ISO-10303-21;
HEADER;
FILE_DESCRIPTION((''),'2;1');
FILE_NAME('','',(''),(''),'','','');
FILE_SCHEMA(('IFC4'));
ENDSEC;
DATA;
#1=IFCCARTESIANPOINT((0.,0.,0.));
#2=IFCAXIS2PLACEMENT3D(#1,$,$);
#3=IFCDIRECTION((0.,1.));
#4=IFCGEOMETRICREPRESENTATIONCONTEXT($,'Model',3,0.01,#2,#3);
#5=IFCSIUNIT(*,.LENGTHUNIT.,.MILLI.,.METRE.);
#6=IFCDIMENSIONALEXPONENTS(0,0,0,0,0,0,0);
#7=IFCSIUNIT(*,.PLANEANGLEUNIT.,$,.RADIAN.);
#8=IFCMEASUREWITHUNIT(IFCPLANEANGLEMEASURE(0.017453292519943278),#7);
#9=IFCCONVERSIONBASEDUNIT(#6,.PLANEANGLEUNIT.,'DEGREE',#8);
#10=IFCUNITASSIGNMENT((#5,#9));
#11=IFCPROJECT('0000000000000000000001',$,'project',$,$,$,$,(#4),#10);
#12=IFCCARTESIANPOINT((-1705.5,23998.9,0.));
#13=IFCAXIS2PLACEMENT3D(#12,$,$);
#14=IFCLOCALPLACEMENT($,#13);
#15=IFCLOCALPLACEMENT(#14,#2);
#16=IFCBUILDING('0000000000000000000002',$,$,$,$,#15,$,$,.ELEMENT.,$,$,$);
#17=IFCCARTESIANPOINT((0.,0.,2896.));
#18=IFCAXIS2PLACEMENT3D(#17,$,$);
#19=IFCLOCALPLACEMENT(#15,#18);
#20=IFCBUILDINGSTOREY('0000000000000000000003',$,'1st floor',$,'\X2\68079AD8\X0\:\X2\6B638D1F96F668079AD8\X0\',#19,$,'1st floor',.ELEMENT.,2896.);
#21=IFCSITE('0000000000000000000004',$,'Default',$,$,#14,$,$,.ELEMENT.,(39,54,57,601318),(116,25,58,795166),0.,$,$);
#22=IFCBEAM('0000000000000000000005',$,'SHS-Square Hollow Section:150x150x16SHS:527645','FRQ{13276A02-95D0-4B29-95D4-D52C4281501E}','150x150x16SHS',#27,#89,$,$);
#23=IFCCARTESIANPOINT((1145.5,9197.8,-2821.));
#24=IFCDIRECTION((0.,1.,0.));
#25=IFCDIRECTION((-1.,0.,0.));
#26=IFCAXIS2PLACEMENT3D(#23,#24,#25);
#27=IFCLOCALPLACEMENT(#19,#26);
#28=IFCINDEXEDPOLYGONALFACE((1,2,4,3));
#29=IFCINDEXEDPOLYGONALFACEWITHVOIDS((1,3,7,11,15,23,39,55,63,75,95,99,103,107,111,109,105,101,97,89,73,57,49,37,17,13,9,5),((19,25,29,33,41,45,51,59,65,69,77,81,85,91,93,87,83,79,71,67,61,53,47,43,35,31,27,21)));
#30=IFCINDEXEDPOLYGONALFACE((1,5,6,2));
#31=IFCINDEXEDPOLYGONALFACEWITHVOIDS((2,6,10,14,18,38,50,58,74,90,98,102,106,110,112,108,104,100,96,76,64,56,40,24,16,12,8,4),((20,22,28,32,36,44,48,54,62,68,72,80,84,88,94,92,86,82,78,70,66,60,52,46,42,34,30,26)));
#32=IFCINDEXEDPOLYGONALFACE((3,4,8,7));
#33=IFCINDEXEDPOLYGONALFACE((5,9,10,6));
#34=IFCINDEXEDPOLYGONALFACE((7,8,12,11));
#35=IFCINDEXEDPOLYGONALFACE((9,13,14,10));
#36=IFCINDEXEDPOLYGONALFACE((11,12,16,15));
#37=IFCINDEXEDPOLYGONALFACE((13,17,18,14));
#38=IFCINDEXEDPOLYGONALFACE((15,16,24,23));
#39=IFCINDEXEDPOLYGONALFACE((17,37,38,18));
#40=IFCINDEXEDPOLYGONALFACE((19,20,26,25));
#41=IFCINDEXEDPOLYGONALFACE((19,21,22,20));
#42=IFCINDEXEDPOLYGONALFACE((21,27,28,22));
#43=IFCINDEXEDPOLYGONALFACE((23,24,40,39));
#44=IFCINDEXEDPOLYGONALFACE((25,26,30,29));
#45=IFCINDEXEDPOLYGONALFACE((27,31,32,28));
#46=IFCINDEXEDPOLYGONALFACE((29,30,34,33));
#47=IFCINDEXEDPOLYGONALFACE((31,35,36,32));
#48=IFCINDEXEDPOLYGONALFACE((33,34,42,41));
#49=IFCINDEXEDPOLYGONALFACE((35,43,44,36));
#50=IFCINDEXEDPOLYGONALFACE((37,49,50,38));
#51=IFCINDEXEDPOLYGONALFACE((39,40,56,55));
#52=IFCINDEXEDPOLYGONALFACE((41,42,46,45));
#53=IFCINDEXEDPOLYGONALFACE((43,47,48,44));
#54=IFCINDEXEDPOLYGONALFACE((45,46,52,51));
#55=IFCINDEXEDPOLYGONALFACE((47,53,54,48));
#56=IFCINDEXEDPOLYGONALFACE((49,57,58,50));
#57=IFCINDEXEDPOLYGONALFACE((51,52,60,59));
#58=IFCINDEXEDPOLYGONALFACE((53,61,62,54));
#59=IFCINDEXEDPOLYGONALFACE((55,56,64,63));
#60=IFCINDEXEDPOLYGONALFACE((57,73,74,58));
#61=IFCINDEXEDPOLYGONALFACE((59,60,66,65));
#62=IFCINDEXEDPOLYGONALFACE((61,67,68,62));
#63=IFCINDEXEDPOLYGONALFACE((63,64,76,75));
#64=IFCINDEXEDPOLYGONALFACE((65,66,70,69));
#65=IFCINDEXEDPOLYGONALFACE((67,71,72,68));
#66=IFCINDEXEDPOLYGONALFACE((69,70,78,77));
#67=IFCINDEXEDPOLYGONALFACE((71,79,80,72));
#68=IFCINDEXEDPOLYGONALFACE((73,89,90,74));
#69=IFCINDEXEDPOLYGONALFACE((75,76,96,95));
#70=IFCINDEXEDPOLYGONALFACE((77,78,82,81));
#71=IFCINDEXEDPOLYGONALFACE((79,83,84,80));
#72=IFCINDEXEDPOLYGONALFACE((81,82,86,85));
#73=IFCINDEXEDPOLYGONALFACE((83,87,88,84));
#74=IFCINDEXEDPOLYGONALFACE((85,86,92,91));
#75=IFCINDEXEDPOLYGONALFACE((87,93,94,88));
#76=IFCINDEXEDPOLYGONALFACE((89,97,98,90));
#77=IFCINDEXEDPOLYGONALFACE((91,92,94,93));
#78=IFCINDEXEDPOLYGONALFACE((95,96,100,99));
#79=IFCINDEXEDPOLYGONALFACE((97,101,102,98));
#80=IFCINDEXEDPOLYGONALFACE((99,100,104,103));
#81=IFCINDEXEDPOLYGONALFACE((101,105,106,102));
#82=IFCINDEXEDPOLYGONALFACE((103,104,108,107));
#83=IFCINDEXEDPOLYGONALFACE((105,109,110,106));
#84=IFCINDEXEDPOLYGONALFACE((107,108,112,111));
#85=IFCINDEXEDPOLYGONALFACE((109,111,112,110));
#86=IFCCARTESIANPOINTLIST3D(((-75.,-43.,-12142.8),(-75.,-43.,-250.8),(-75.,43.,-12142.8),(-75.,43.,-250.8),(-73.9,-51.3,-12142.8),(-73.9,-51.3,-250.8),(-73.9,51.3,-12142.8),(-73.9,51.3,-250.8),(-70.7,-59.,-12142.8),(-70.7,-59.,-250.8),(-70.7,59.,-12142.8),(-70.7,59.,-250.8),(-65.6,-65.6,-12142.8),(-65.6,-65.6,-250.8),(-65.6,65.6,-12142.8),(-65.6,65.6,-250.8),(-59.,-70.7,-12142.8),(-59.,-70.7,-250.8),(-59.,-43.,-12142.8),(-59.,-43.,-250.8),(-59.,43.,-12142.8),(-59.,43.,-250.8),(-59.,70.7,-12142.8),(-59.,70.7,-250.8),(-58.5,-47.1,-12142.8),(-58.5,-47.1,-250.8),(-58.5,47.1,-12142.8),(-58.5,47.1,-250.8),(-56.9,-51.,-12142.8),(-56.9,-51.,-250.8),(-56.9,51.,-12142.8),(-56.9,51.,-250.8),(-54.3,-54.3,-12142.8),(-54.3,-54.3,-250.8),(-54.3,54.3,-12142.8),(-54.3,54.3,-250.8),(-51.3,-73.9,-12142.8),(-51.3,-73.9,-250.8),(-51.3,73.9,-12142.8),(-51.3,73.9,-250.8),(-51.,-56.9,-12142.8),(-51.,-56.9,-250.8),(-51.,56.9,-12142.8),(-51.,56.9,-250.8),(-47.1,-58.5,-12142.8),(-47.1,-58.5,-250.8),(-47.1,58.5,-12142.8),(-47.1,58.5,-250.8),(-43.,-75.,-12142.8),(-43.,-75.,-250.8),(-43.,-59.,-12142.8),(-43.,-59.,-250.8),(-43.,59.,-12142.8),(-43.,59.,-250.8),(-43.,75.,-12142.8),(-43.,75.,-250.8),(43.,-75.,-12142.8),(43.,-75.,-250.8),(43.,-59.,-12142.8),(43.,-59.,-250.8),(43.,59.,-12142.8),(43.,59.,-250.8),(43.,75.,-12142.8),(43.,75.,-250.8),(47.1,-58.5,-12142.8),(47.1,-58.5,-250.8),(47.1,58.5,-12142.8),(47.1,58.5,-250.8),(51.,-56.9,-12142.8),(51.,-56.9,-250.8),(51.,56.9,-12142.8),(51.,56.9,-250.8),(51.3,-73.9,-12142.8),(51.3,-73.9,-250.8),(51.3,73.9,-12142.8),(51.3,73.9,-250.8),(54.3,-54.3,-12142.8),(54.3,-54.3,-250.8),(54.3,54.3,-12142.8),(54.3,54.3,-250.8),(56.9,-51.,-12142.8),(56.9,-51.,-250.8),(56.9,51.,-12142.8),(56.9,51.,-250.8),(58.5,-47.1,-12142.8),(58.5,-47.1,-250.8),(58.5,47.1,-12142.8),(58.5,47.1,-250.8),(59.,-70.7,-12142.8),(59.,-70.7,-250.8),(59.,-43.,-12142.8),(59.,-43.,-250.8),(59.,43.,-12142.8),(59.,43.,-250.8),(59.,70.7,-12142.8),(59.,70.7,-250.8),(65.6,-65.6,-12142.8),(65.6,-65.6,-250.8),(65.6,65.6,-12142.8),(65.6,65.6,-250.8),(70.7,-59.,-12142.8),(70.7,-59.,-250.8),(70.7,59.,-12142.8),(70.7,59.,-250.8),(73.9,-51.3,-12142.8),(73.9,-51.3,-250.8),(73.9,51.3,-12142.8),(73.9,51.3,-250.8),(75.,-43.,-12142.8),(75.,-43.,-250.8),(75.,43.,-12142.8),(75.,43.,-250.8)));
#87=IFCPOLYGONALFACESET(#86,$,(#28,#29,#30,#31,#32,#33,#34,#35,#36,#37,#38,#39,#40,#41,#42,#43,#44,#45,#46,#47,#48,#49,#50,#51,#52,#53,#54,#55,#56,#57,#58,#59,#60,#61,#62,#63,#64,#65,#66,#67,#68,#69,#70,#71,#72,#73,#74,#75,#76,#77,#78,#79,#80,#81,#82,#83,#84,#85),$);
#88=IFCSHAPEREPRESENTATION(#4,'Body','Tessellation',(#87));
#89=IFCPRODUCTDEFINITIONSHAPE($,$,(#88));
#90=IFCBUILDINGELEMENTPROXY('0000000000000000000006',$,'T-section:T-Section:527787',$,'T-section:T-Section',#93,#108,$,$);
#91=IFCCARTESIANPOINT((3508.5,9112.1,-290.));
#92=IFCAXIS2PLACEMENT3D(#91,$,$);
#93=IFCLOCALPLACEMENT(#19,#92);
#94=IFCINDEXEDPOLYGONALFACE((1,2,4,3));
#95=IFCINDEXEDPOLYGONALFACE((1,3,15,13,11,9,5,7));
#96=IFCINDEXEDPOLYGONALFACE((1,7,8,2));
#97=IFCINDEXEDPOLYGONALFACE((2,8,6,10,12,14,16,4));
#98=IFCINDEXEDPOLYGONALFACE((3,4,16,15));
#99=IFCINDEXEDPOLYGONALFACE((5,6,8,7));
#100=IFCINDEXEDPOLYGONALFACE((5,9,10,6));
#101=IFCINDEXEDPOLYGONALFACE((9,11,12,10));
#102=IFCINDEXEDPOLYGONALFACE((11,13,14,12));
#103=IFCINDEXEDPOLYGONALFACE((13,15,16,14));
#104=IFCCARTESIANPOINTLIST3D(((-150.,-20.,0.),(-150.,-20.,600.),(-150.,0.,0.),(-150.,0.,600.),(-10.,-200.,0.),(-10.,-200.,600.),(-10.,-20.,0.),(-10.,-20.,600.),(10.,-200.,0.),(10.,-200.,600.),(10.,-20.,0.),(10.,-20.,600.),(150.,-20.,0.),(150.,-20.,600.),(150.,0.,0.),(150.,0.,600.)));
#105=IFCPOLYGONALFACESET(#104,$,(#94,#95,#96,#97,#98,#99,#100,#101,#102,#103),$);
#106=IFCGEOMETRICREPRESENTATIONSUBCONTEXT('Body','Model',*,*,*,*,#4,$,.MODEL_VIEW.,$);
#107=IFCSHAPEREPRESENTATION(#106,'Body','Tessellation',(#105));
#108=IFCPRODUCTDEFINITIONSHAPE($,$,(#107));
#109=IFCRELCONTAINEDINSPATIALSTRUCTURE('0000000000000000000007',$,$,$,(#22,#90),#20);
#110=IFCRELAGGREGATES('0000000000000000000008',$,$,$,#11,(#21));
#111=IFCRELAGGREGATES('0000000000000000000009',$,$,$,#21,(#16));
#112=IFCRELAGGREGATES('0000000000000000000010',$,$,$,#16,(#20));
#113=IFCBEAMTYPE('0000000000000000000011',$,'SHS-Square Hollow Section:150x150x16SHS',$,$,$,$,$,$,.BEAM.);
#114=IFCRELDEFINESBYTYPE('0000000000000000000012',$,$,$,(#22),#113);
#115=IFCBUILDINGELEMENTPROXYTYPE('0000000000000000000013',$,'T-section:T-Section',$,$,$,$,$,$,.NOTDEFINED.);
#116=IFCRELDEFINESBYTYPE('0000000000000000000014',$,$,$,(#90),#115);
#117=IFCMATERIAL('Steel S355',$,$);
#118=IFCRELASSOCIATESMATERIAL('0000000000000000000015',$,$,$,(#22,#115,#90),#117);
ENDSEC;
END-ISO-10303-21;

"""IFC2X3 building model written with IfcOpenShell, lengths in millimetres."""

from ifc_helpers import new_model, entity, si_unit, converted_unit, direction, frame, origin, origin_2d, place, context, subcontext, project, spatial, polyline, hollow_rectangle, outline, extrude, clip, halfspace, source, transform, mapped, material, type_object, type_shapes, element, save


model = new_model("IFC2X3")

# Units and contexts
model_context = context("Model", 3, precision=0.01, world=origin(), true_north=direction((0.0, 1.0)))
body_context = subcontext(model_context, "Body", "Model", "MODEL_VIEW")
ifc_project = project(units=[si_unit("LENGTHUNIT", "METRE", prefix="MILLI"), converted_unit("PLANEANGLEUNIT", "DEGREE", entity("IfcPlaneAngleMeasure", 0.017453292519943278), si_unit("PLANEANGLEUNIT", "RADIAN"), dimensions=[0, 0, 0, 0, 0, 0, 0])], contexts=[model_context])

# Site, building, storey
site_placement = place(None, frame((-1705.5, 23998.9, 0.0)))
site = spatial("IfcSite", under=ifc_project, at=site_placement, Name="Default", CompositionType="ELEMENT", RefLatitude=(39, 54, 57, 601318), RefLongitude=(116, 25, 58, 795166), RefElevation=0.0)
building_placement = place(site_placement, origin())
building = spatial("IfcBuilding", under=site, at=building_placement, CompositionType="ELEMENT")
storey_placement = place(building_placement, frame((0.0, 0.0, 2896.0)))
storey = spatial("IfcBuildingStorey", under=building, at=storey_placement, Name="1st floor", ObjectType="标高:正负零标高", LongName="1st floor", CompositionType="ELEMENT", Elevation=2896.0)

# Shared definitions
ifc_material_1 = material(Name="Steel S355")

# Shared definitions
beam_type_1 = type_object("IfcBeamType", Name="SHS-Square Hollow Section:150x150x16SHS", PredefinedType="BEAM")

# Beam
beam_1_placement = place(storey_placement, frame((1145.5, 9197.8, -2821.0), z_axis=(0.0, 1.0, 0.0), x_axis=(-1.0, 0.0, 0.0)))
element("IfcBeam", 1, at=beam_1_placement, inside=storey, type_object=beam_type_1, material=ifc_material_1, Name="SHS-Square Hollow Section:150x150x16SHS:527645", Description="FRQ{13276A02-95D0-4B29-95D4-D52C4281501E}", ObjectType="150x150x16SHS", context=model_context, shape_type="Clipping", body=[
    clip(clip(extrude(hollow_rectangle(XDim=150.0, YDim=150.0, WallThickness=16.0, InnerFilletRadius=16.0, OuterFilletRadius=32.0, at=origin_2d()), origin(), (0.0, 0.0, -1.0), 12398.9), halfspace(frame((1145.5, -75.0, -12142.8), z_axis=(0.0, 0.0, 1.0), x_axis=(1.0, 0.0, 0.0)), True)), halfspace(frame((1145.5, -75.0, -250.8), z_axis=(0.0, 0.0, -1.0), x_axis=(-1.0, 0.0, 0.0)), True)),
])

# Building element proxy
building_element_proxy_type_1 = type_object("IfcBuildingElementProxyType", Name="T-section:T-Section", PredefinedType="NOTDEFINED", material=ifc_material_1)
shared_shape_1 = source(origin(), body_context, "Body", "SweptSolid", [
    extrude(outline(polyline([(-10.0, -140.0), (10.0, -140.0), (10.0, 40.0), (150.0, 40.0), (150.0, 60.0), (-150.0, 60.0), (-150.0, 40.0), (-10.0, 40.0), (-10.0, -140.0)])), frame((0.0, -60.0, 0.0)), (0.0, 0.0, 1.0), 600.0),
])
type_shapes(building_element_proxy_type_1, [shared_shape_1])
proxy_1_placement = place(storey_placement, frame((3508.5, 9112.1, -290.0)))
element("IfcBuildingElementProxy", 2, at=proxy_1_placement, inside=storey, type_object=building_element_proxy_type_1, material=ifc_material_1, Name="T-section:T-Section:527787", ObjectType="T-section:T-Section", context=body_context, shape_type="MappedRepresentation", body=[
    mapped(shared_shape_1, transform((0.0, 0.0, 0.0), scale=1.0)),
])

save(model, "model.ifc")
